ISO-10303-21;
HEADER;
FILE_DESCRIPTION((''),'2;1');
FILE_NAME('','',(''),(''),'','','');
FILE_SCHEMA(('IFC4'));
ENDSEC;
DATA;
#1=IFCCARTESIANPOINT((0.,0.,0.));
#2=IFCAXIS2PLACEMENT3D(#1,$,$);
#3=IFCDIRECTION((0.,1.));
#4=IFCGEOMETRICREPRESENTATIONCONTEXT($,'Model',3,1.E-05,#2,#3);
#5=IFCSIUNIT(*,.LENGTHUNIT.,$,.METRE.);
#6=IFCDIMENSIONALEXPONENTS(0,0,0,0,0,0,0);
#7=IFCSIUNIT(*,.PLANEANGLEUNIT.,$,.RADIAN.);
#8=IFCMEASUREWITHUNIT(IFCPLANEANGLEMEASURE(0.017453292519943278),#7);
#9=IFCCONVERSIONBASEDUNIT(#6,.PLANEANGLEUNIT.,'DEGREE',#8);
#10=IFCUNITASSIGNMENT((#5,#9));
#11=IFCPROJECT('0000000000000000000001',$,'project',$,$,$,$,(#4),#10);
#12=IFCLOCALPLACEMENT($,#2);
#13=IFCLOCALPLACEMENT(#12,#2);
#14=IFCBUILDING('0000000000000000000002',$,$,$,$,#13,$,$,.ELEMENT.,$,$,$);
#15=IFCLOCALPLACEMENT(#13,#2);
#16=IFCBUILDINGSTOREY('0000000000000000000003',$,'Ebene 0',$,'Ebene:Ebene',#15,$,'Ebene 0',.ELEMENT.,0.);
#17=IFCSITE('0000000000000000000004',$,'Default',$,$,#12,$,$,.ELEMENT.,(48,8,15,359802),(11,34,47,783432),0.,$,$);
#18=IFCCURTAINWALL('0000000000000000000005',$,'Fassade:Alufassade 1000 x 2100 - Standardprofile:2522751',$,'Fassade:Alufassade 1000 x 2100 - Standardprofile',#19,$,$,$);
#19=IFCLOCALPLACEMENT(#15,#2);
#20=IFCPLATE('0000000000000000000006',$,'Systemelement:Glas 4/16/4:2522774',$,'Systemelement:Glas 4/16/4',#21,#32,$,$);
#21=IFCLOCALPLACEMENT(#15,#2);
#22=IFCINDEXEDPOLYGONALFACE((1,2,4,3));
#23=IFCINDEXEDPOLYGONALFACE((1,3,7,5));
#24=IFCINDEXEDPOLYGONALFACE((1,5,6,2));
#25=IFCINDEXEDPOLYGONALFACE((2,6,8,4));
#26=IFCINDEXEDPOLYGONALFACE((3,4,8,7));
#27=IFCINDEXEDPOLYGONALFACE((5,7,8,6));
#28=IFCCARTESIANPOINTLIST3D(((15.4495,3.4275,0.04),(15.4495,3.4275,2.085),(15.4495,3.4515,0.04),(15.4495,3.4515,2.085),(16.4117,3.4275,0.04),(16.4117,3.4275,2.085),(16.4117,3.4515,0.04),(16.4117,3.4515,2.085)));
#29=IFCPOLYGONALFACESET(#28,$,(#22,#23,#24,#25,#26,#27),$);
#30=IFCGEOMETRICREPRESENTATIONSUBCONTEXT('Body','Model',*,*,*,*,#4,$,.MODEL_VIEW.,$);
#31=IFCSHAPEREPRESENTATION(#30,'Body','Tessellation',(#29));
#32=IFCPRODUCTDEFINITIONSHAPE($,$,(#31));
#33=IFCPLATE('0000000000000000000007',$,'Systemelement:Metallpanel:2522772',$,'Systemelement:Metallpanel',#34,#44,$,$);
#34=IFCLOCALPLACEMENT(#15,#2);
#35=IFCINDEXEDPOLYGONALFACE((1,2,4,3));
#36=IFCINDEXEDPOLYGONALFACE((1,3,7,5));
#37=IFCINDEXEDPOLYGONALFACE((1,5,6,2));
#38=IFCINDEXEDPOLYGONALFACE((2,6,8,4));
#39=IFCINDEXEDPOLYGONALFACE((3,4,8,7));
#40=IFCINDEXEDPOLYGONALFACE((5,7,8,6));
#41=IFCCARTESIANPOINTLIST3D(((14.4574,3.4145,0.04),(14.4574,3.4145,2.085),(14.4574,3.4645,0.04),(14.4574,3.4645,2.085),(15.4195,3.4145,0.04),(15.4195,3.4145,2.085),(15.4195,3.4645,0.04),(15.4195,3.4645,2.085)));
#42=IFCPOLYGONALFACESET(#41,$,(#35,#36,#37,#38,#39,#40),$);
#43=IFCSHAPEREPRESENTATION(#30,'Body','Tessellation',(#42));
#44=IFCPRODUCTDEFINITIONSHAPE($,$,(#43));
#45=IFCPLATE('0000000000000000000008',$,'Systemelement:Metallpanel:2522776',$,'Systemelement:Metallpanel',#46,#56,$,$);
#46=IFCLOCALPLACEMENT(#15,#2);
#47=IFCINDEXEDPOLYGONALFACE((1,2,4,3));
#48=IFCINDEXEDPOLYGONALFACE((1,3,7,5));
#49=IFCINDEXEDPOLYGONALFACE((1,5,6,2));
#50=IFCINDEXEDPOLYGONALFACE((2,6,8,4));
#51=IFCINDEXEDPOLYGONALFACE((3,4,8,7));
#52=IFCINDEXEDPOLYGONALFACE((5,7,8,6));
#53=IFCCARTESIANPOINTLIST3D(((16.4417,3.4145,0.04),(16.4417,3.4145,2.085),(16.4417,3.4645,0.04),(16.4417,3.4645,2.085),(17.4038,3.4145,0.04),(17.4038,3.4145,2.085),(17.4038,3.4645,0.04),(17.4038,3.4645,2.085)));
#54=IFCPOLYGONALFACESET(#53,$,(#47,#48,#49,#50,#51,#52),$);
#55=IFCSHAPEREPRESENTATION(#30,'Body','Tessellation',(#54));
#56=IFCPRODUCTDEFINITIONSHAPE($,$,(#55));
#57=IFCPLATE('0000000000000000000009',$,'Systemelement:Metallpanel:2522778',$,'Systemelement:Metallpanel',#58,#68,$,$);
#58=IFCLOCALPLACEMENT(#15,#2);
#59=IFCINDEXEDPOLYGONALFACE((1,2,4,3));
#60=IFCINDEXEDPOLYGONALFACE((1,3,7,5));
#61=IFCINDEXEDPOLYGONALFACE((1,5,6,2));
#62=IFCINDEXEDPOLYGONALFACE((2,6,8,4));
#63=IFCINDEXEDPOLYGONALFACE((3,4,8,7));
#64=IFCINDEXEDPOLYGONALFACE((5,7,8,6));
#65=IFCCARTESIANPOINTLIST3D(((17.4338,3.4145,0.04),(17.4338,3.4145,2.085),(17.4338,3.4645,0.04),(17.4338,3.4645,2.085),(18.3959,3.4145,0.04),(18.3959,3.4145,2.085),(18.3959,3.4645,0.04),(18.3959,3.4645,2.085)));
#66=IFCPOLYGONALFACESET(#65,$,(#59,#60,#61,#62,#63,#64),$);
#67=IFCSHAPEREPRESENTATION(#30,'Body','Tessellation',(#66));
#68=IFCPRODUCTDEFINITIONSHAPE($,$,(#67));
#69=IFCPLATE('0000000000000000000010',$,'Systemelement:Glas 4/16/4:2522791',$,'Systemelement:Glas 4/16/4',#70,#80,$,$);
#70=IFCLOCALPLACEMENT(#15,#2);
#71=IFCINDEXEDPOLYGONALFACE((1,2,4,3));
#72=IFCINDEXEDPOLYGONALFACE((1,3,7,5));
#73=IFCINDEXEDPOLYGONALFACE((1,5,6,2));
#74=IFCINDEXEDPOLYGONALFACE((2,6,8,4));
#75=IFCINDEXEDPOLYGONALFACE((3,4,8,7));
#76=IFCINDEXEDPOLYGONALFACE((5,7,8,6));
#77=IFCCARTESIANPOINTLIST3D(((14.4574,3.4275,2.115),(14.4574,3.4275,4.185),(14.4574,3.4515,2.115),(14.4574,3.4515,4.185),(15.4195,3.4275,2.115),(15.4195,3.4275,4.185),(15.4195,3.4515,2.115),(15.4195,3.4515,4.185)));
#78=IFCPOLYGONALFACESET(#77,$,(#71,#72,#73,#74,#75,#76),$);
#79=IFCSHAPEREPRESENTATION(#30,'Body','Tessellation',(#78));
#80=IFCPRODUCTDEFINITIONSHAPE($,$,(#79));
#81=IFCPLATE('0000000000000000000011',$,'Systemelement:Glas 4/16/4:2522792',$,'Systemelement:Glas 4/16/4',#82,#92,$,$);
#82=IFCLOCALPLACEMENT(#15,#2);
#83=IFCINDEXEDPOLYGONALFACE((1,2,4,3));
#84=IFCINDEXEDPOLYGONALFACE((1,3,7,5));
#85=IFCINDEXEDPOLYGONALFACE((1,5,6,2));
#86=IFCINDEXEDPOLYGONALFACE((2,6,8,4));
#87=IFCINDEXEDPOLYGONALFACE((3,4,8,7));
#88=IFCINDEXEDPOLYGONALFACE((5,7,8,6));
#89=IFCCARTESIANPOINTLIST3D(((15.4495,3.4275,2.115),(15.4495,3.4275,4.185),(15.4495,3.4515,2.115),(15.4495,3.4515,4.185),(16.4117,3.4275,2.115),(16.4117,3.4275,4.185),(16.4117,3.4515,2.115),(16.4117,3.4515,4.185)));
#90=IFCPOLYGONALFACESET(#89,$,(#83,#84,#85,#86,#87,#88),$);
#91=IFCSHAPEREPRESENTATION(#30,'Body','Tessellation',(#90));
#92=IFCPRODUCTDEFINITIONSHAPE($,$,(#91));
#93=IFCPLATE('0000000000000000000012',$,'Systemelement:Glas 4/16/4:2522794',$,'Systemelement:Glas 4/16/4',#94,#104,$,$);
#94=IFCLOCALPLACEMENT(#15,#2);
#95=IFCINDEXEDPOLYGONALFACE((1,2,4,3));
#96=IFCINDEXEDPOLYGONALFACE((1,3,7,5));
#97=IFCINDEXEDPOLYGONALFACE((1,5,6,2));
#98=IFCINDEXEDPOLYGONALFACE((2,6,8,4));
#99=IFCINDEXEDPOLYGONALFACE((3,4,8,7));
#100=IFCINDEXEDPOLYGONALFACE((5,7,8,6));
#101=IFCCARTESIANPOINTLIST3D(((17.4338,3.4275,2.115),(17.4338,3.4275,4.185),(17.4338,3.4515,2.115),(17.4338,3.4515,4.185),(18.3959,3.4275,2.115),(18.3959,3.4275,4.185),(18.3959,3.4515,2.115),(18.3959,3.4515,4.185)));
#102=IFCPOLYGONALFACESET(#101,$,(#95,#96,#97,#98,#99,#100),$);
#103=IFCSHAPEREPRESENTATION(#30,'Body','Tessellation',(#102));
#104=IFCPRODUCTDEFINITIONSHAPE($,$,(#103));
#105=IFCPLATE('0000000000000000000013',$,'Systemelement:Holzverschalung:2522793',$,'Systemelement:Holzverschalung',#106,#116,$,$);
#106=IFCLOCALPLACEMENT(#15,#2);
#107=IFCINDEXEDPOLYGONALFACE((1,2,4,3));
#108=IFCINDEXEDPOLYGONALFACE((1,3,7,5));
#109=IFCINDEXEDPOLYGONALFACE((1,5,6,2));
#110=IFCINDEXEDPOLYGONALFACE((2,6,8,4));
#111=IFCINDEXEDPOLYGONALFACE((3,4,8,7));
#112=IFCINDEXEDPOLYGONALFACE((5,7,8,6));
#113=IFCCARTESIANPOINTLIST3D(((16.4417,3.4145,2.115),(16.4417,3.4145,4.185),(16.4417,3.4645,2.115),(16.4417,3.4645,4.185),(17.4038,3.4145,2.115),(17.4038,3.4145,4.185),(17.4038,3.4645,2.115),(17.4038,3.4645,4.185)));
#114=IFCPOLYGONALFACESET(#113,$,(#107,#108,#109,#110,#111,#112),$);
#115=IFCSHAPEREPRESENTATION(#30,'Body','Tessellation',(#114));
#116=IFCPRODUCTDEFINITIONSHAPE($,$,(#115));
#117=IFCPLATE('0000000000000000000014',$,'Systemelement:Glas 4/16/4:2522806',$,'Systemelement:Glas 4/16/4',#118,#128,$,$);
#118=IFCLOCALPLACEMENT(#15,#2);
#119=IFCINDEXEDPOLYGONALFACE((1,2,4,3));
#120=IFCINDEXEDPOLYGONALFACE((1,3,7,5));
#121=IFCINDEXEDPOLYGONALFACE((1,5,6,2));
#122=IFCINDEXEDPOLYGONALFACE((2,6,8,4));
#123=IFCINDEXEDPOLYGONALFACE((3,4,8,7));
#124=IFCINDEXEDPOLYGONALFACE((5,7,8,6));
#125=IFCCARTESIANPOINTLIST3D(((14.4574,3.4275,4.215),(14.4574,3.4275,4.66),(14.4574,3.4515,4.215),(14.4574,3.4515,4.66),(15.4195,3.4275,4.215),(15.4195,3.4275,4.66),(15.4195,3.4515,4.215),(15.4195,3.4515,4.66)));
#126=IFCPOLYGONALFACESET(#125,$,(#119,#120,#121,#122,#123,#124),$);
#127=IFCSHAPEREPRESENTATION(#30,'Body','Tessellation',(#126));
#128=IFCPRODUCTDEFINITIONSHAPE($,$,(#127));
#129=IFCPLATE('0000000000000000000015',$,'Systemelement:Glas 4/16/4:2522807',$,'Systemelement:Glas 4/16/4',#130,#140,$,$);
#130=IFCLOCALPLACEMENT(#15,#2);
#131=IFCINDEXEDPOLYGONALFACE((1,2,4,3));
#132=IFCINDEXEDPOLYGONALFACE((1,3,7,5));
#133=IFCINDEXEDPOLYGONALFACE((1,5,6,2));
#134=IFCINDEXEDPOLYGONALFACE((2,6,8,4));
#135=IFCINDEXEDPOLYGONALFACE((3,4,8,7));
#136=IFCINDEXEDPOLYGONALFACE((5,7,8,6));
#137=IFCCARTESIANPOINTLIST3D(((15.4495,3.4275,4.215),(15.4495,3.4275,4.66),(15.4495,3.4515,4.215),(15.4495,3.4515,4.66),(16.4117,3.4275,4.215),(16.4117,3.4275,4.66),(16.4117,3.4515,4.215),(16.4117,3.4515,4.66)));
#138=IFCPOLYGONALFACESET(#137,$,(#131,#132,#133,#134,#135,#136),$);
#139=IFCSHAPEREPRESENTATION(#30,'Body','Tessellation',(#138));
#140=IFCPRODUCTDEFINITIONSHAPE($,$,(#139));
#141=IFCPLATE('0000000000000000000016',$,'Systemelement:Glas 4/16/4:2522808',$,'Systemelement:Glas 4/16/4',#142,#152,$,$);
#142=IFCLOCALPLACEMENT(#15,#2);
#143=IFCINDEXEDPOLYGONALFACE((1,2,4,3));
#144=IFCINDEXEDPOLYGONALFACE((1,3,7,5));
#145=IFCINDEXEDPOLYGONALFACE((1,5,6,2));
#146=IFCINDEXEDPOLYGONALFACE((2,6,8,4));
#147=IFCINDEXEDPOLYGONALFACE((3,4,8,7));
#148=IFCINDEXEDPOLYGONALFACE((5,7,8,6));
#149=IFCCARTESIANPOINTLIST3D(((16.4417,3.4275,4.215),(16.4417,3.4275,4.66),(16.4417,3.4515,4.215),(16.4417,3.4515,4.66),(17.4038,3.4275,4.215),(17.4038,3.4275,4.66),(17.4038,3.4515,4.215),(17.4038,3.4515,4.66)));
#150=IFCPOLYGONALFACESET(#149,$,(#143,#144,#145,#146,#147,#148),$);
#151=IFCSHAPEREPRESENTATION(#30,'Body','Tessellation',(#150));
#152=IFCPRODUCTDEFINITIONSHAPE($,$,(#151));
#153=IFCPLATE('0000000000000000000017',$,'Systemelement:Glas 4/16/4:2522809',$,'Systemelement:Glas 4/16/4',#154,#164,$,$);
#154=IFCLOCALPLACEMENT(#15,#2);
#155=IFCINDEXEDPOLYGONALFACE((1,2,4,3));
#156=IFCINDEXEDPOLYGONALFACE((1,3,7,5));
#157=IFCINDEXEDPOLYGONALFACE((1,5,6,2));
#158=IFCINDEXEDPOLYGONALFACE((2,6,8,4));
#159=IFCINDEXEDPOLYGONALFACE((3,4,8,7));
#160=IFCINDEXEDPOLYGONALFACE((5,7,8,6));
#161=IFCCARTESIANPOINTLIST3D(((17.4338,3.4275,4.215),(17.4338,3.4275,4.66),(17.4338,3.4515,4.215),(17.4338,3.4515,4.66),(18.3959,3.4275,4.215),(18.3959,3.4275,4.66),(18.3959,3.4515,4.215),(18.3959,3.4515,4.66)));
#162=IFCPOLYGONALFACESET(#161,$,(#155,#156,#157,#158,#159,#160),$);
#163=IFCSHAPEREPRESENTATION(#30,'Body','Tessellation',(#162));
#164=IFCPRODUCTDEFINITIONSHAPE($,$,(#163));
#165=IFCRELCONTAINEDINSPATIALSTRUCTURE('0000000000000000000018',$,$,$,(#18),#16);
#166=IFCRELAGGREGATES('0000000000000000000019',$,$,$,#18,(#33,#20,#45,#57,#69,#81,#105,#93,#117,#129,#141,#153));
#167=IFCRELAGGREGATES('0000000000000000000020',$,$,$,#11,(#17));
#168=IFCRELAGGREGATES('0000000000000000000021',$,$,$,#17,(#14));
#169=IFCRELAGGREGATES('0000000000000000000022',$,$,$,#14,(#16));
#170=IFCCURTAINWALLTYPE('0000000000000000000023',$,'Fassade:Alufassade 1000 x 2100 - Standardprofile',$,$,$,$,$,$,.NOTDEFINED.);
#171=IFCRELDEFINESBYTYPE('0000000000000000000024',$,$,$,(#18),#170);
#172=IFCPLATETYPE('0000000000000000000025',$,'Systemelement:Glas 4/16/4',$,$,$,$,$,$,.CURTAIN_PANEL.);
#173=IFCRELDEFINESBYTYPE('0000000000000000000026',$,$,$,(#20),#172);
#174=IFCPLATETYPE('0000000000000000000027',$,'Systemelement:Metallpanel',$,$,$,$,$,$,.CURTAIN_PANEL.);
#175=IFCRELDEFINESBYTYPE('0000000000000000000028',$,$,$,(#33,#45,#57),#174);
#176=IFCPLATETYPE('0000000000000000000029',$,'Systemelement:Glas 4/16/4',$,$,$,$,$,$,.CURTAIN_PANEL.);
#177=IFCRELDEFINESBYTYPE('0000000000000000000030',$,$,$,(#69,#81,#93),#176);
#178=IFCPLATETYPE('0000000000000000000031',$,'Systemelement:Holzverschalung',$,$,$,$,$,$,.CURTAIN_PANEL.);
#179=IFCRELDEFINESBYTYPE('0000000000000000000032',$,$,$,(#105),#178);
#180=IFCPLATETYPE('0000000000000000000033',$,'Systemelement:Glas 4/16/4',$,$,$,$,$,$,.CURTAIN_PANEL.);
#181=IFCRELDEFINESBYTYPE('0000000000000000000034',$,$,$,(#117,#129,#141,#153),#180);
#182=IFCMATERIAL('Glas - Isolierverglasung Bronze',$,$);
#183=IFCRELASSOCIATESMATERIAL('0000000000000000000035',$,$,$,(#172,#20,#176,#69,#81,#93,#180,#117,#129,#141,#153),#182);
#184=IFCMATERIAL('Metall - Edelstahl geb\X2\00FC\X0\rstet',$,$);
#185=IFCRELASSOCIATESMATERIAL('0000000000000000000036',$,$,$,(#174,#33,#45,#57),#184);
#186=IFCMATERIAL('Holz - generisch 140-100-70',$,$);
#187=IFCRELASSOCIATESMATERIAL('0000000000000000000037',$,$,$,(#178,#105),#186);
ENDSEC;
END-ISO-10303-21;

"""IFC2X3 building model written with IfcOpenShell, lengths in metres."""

from ifc_helpers import new_model, entity, si_unit, converted_unit, direction, frame, origin, origin_2d_with_axis, place, context, subcontext, project, spatial, rectangle, extrude, source, transform, mapped, material, type_object, type_shapes, element, aggregate, save


model = new_model("IFC2X3")

# Units and contexts
model_context = context("Model", 3, precision=1e-05, world=origin(), true_north=direction((0.0, 1.0)))
body_context = subcontext(model_context, "Body", "Model", "MODEL_VIEW")
ifc_project = project(units=[si_unit("LENGTHUNIT", "METRE"), converted_unit("PLANEANGLEUNIT", "DEGREE", entity("IfcPlaneAngleMeasure", 0.017453292519943278), si_unit("PLANEANGLEUNIT", "RADIAN"), dimensions=[0, 0, 0, 0, 0, 0, 0])], contexts=[model_context])

# Site, building, storey
site_placement = place(None, origin())
site = spatial("IfcSite", under=ifc_project, at=site_placement, Name="Default", CompositionType="ELEMENT", RefLatitude=(48, 8, 15, 359802), RefLongitude=(11, 34, 47, 783432), RefElevation=0.0)
building_placement = place(site_placement, origin())
building = spatial("IfcBuilding", under=site, at=building_placement, CompositionType="ELEMENT")
storey_placement = place(building_placement, origin())
storey = spatial("IfcBuildingStorey", under=building, at=storey_placement, Name="Ebene 0", ObjectType="Ebene:Ebene", LongName="Ebene 0", CompositionType="ELEMENT", Elevation=0.0)

# Curtain wall, plates
curtain_wall_type = type_object("IfcCurtainWallType", Name="Fassade:Alufassade 1000 x 2100 - Standardprofile", PredefinedType="NOTDEFINED")
curtain_wall_placement = place(storey_placement, origin())
curtain_wall = element("IfcCurtainWall", 1, at=curtain_wall_placement, inside=storey, type_object=curtain_wall_type, Name="Fassade:Alufassade 1000 x 2100 - Standardprofile:2522751", ObjectType="Fassade:Alufassade 1000 x 2100 - Standardprofile")
ifc_material_1 = material(Name="Glas - Isolierverglasung Bronze")
plate_type_1 = type_object("IfcPlateType", Name="Systemelement:Glas 4/16/4", PredefinedType="CURTAIN_PANEL", material=ifc_material_1)
shared_shape_1 = source(origin(), body_context, "Body", "SweptSolid", [
    extrude(rectangle(XDim=0.024, YDim=0.9621, at=origin_2d_with_axis()), frame((0.0, 0.0, 0.0), z_axis=(0.0, 0.0, 1.0), x_axis=(0.0, 1.0, 0.0)), (0.0, 0.0, 1.0), 2.045),
])
type_shapes(plate_type_1, [shared_shape_1])
plate_1_placement = place(curtain_wall_placement, frame((15.9306, 3.4395, 0.04)))
plate_1 = element("IfcPlate", 2, at=plate_1_placement, type_object=plate_type_1, material=ifc_material_1, Name="Systemelement:Glas 4/16/4:2522774", ObjectType="Systemelement:Glas 4/16/4", context=body_context, shape_type="MappedRepresentation", body=[
    mapped(shared_shape_1, transform((0.0, 0.0, 0.0), scale=1.0)),
])
ifc_material_2 = material(Name="Metall - Edelstahl gebürstet")
plate_type_2 = type_object("IfcPlateType", Name="Systemelement:Metallpanel", PredefinedType="CURTAIN_PANEL", material=ifc_material_2)
shared_shape_2 = source(origin(), body_context, "Body", "SweptSolid", [
    extrude(rectangle(XDim=0.05, YDim=0.9621, at=origin_2d_with_axis()), frame((0.0, 0.0, 0.0), z_axis=(0.0, 0.0, 1.0), x_axis=(0.0, 1.0, 0.0)), (0.0, 0.0, 1.0), 2.045),
])
type_shapes(plate_type_2, [shared_shape_2])
plate_2_placement = place(curtain_wall_placement, frame((14.9384, 3.4395, 0.04)))
plate_2 = element("IfcPlate", 3, at=plate_2_placement, type_object=plate_type_2, material=ifc_material_2, Name="Systemelement:Metallpanel:2522772", ObjectType="Systemelement:Metallpanel", context=body_context, shape_type="MappedRepresentation", body=[
    mapped(shared_shape_2, transform((0.0, 0.0, 0.0), scale=1.0)),
])
plate_3_placement = place(curtain_wall_placement, frame((16.9227, 3.4395, 0.04)))
plate_3 = element("IfcPlate", 4, at=plate_3_placement, type_object=plate_type_2, material=ifc_material_2, Name="Systemelement:Metallpanel:2522776", ObjectType="Systemelement:Metallpanel", context=body_context, shape_type="MappedRepresentation", body=[
    mapped(shared_shape_2, transform((0.0, 0.0, 0.0), scale=1.0)),
])
plate_4_placement = place(curtain_wall_placement, frame((17.9149, 3.4395, 0.04)))
plate_4 = element("IfcPlate", 5, at=plate_4_placement, type_object=plate_type_2, material=ifc_material_2, Name="Systemelement:Metallpanel:2522778", ObjectType="Systemelement:Metallpanel", context=body_context, shape_type="MappedRepresentation", body=[
    mapped(shared_shape_2, transform((0.0, 0.0, 0.0), scale=1.0)),
])
plate_type_3 = type_object("IfcPlateType", Name="Systemelement:Glas 4/16/4", PredefinedType="CURTAIN_PANEL", material=ifc_material_1)
shared_shape_3 = source(origin(), body_context, "Body", "SweptSolid", [
    extrude(rectangle(XDim=0.024, YDim=0.9621, at=origin_2d_with_axis()), frame((0.0, 0.0, 0.0), z_axis=(0.0, 0.0, 1.0), x_axis=(0.0, 1.0, 0.0)), (0.0, 0.0, 1.0), 2.07),
])
type_shapes(plate_type_3, [shared_shape_3])
plate_5_placement = place(curtain_wall_placement, frame((14.9384, 3.4395, 2.115)))
plate_5 = element("IfcPlate", 6, at=plate_5_placement, type_object=plate_type_3, material=ifc_material_1, Name="Systemelement:Glas 4/16/4:2522791", ObjectType="Systemelement:Glas 4/16/4", context=body_context, shape_type="MappedRepresentation", body=[
    mapped(shared_shape_3, transform((0.0, 0.0, 0.0), scale=1.0)),
])
plate_6_placement = place(curtain_wall_placement, frame((15.9306, 3.4395, 2.115)))
plate_6 = element("IfcPlate", 7, at=plate_6_placement, type_object=plate_type_3, material=ifc_material_1, Name="Systemelement:Glas 4/16/4:2522792", ObjectType="Systemelement:Glas 4/16/4", context=body_context, shape_type="MappedRepresentation", body=[
    mapped(shared_shape_3, transform((0.0, 0.0, 0.0), scale=1.0)),
])
plate_7_placement = place(curtain_wall_placement, frame((17.9149, 3.4395, 2.115)))
plate_7 = element("IfcPlate", 8, at=plate_7_placement, type_object=plate_type_3, material=ifc_material_1, Name="Systemelement:Glas 4/16/4:2522794", ObjectType="Systemelement:Glas 4/16/4", context=body_context, shape_type="MappedRepresentation", body=[
    mapped(shared_shape_3, transform((0.0, 0.0, 0.0), scale=1.0)),
])
ifc_material_3 = material(Name="Holz - generisch 140-100-70")
plate_type_4 = type_object("IfcPlateType", Name="Systemelement:Holzverschalung", PredefinedType="CURTAIN_PANEL", material=ifc_material_3)
shared_shape_4 = source(origin(), body_context, "Body", "SweptSolid", [
    extrude(rectangle(XDim=0.05, YDim=0.9621, at=origin_2d_with_axis()), frame((0.0, 0.0, 0.0), z_axis=(0.0, 0.0, 1.0), x_axis=(0.0, 1.0, 0.0)), (0.0, 0.0, 1.0), 2.07),
])
type_shapes(plate_type_4, [shared_shape_4])
plate_8_placement = place(curtain_wall_placement, frame((16.9227, 3.4395, 2.115)))
plate_8 = element("IfcPlate", 9, at=plate_8_placement, type_object=plate_type_4, material=ifc_material_3, Name="Systemelement:Holzverschalung:2522793", ObjectType="Systemelement:Holzverschalung", context=body_context, shape_type="MappedRepresentation", body=[
    mapped(shared_shape_4, transform((0.0, 0.0, 0.0), scale=1.0)),
])
plate_type_5 = type_object("IfcPlateType", Name="Systemelement:Glas 4/16/4", PredefinedType="CURTAIN_PANEL", material=ifc_material_1)
shared_shape_5 = source(origin(), body_context, "Body", "SweptSolid", [
    extrude(rectangle(XDim=0.024, YDim=0.9621, at=origin_2d_with_axis()), frame((0.0, 0.0, 0.0), z_axis=(0.0, 0.0, 1.0), x_axis=(0.0, 1.0, 0.0)), (0.0, 0.0, 1.0), 0.445),
])
type_shapes(plate_type_5, [shared_shape_5])
plate_9_placement = place(curtain_wall_placement, frame((14.9384, 3.4395, 4.215)))
plate_9 = element("IfcPlate", 10, at=plate_9_placement, type_object=plate_type_5, material=ifc_material_1, Name="Systemelement:Glas 4/16/4:2522806", ObjectType="Systemelement:Glas 4/16/4", context=body_context, shape_type="MappedRepresentation", body=[
    mapped(shared_shape_5, transform((0.0, 0.0, 0.0), scale=1.0)),
])
plate_10_placement = place(curtain_wall_placement, frame((15.9306, 3.4395, 4.215)))
plate_10 = element("IfcPlate", 11, at=plate_10_placement, type_object=plate_type_5, material=ifc_material_1, Name="Systemelement:Glas 4/16/4:2522807", ObjectType="Systemelement:Glas 4/16/4", context=body_context, shape_type="MappedRepresentation", body=[
    mapped(shared_shape_5, transform((0.0, 0.0, 0.0), scale=1.0)),
])
plate_11_placement = place(curtain_wall_placement, frame((16.9227, 3.4395, 4.215)))
plate_11 = element("IfcPlate", 12, at=plate_11_placement, type_object=plate_type_5, material=ifc_material_1, Name="Systemelement:Glas 4/16/4:2522808", ObjectType="Systemelement:Glas 4/16/4", context=body_context, shape_type="MappedRepresentation", body=[
    mapped(shared_shape_5, transform((0.0, 0.0, 0.0), scale=1.0)),
])
plate_12_placement = place(curtain_wall_placement, frame((17.9149, 3.4395, 4.215)))
plate_12 = element("IfcPlate", 13, at=plate_12_placement, type_object=plate_type_5, material=ifc_material_1, Name="Systemelement:Glas 4/16/4:2522809", ObjectType="Systemelement:Glas 4/16/4", context=body_context, shape_type="MappedRepresentation", body=[
    mapped(shared_shape_5, transform((0.0, 0.0, 0.0), scale=1.0)),
])
aggregate(curtain_wall, [plate_2, plate_1, plate_3, plate_4, plate_5, plate_6, plate_8, plate_7, plate_9, plate_10, plate_11, plate_12])

save(model, "model.ifc")
